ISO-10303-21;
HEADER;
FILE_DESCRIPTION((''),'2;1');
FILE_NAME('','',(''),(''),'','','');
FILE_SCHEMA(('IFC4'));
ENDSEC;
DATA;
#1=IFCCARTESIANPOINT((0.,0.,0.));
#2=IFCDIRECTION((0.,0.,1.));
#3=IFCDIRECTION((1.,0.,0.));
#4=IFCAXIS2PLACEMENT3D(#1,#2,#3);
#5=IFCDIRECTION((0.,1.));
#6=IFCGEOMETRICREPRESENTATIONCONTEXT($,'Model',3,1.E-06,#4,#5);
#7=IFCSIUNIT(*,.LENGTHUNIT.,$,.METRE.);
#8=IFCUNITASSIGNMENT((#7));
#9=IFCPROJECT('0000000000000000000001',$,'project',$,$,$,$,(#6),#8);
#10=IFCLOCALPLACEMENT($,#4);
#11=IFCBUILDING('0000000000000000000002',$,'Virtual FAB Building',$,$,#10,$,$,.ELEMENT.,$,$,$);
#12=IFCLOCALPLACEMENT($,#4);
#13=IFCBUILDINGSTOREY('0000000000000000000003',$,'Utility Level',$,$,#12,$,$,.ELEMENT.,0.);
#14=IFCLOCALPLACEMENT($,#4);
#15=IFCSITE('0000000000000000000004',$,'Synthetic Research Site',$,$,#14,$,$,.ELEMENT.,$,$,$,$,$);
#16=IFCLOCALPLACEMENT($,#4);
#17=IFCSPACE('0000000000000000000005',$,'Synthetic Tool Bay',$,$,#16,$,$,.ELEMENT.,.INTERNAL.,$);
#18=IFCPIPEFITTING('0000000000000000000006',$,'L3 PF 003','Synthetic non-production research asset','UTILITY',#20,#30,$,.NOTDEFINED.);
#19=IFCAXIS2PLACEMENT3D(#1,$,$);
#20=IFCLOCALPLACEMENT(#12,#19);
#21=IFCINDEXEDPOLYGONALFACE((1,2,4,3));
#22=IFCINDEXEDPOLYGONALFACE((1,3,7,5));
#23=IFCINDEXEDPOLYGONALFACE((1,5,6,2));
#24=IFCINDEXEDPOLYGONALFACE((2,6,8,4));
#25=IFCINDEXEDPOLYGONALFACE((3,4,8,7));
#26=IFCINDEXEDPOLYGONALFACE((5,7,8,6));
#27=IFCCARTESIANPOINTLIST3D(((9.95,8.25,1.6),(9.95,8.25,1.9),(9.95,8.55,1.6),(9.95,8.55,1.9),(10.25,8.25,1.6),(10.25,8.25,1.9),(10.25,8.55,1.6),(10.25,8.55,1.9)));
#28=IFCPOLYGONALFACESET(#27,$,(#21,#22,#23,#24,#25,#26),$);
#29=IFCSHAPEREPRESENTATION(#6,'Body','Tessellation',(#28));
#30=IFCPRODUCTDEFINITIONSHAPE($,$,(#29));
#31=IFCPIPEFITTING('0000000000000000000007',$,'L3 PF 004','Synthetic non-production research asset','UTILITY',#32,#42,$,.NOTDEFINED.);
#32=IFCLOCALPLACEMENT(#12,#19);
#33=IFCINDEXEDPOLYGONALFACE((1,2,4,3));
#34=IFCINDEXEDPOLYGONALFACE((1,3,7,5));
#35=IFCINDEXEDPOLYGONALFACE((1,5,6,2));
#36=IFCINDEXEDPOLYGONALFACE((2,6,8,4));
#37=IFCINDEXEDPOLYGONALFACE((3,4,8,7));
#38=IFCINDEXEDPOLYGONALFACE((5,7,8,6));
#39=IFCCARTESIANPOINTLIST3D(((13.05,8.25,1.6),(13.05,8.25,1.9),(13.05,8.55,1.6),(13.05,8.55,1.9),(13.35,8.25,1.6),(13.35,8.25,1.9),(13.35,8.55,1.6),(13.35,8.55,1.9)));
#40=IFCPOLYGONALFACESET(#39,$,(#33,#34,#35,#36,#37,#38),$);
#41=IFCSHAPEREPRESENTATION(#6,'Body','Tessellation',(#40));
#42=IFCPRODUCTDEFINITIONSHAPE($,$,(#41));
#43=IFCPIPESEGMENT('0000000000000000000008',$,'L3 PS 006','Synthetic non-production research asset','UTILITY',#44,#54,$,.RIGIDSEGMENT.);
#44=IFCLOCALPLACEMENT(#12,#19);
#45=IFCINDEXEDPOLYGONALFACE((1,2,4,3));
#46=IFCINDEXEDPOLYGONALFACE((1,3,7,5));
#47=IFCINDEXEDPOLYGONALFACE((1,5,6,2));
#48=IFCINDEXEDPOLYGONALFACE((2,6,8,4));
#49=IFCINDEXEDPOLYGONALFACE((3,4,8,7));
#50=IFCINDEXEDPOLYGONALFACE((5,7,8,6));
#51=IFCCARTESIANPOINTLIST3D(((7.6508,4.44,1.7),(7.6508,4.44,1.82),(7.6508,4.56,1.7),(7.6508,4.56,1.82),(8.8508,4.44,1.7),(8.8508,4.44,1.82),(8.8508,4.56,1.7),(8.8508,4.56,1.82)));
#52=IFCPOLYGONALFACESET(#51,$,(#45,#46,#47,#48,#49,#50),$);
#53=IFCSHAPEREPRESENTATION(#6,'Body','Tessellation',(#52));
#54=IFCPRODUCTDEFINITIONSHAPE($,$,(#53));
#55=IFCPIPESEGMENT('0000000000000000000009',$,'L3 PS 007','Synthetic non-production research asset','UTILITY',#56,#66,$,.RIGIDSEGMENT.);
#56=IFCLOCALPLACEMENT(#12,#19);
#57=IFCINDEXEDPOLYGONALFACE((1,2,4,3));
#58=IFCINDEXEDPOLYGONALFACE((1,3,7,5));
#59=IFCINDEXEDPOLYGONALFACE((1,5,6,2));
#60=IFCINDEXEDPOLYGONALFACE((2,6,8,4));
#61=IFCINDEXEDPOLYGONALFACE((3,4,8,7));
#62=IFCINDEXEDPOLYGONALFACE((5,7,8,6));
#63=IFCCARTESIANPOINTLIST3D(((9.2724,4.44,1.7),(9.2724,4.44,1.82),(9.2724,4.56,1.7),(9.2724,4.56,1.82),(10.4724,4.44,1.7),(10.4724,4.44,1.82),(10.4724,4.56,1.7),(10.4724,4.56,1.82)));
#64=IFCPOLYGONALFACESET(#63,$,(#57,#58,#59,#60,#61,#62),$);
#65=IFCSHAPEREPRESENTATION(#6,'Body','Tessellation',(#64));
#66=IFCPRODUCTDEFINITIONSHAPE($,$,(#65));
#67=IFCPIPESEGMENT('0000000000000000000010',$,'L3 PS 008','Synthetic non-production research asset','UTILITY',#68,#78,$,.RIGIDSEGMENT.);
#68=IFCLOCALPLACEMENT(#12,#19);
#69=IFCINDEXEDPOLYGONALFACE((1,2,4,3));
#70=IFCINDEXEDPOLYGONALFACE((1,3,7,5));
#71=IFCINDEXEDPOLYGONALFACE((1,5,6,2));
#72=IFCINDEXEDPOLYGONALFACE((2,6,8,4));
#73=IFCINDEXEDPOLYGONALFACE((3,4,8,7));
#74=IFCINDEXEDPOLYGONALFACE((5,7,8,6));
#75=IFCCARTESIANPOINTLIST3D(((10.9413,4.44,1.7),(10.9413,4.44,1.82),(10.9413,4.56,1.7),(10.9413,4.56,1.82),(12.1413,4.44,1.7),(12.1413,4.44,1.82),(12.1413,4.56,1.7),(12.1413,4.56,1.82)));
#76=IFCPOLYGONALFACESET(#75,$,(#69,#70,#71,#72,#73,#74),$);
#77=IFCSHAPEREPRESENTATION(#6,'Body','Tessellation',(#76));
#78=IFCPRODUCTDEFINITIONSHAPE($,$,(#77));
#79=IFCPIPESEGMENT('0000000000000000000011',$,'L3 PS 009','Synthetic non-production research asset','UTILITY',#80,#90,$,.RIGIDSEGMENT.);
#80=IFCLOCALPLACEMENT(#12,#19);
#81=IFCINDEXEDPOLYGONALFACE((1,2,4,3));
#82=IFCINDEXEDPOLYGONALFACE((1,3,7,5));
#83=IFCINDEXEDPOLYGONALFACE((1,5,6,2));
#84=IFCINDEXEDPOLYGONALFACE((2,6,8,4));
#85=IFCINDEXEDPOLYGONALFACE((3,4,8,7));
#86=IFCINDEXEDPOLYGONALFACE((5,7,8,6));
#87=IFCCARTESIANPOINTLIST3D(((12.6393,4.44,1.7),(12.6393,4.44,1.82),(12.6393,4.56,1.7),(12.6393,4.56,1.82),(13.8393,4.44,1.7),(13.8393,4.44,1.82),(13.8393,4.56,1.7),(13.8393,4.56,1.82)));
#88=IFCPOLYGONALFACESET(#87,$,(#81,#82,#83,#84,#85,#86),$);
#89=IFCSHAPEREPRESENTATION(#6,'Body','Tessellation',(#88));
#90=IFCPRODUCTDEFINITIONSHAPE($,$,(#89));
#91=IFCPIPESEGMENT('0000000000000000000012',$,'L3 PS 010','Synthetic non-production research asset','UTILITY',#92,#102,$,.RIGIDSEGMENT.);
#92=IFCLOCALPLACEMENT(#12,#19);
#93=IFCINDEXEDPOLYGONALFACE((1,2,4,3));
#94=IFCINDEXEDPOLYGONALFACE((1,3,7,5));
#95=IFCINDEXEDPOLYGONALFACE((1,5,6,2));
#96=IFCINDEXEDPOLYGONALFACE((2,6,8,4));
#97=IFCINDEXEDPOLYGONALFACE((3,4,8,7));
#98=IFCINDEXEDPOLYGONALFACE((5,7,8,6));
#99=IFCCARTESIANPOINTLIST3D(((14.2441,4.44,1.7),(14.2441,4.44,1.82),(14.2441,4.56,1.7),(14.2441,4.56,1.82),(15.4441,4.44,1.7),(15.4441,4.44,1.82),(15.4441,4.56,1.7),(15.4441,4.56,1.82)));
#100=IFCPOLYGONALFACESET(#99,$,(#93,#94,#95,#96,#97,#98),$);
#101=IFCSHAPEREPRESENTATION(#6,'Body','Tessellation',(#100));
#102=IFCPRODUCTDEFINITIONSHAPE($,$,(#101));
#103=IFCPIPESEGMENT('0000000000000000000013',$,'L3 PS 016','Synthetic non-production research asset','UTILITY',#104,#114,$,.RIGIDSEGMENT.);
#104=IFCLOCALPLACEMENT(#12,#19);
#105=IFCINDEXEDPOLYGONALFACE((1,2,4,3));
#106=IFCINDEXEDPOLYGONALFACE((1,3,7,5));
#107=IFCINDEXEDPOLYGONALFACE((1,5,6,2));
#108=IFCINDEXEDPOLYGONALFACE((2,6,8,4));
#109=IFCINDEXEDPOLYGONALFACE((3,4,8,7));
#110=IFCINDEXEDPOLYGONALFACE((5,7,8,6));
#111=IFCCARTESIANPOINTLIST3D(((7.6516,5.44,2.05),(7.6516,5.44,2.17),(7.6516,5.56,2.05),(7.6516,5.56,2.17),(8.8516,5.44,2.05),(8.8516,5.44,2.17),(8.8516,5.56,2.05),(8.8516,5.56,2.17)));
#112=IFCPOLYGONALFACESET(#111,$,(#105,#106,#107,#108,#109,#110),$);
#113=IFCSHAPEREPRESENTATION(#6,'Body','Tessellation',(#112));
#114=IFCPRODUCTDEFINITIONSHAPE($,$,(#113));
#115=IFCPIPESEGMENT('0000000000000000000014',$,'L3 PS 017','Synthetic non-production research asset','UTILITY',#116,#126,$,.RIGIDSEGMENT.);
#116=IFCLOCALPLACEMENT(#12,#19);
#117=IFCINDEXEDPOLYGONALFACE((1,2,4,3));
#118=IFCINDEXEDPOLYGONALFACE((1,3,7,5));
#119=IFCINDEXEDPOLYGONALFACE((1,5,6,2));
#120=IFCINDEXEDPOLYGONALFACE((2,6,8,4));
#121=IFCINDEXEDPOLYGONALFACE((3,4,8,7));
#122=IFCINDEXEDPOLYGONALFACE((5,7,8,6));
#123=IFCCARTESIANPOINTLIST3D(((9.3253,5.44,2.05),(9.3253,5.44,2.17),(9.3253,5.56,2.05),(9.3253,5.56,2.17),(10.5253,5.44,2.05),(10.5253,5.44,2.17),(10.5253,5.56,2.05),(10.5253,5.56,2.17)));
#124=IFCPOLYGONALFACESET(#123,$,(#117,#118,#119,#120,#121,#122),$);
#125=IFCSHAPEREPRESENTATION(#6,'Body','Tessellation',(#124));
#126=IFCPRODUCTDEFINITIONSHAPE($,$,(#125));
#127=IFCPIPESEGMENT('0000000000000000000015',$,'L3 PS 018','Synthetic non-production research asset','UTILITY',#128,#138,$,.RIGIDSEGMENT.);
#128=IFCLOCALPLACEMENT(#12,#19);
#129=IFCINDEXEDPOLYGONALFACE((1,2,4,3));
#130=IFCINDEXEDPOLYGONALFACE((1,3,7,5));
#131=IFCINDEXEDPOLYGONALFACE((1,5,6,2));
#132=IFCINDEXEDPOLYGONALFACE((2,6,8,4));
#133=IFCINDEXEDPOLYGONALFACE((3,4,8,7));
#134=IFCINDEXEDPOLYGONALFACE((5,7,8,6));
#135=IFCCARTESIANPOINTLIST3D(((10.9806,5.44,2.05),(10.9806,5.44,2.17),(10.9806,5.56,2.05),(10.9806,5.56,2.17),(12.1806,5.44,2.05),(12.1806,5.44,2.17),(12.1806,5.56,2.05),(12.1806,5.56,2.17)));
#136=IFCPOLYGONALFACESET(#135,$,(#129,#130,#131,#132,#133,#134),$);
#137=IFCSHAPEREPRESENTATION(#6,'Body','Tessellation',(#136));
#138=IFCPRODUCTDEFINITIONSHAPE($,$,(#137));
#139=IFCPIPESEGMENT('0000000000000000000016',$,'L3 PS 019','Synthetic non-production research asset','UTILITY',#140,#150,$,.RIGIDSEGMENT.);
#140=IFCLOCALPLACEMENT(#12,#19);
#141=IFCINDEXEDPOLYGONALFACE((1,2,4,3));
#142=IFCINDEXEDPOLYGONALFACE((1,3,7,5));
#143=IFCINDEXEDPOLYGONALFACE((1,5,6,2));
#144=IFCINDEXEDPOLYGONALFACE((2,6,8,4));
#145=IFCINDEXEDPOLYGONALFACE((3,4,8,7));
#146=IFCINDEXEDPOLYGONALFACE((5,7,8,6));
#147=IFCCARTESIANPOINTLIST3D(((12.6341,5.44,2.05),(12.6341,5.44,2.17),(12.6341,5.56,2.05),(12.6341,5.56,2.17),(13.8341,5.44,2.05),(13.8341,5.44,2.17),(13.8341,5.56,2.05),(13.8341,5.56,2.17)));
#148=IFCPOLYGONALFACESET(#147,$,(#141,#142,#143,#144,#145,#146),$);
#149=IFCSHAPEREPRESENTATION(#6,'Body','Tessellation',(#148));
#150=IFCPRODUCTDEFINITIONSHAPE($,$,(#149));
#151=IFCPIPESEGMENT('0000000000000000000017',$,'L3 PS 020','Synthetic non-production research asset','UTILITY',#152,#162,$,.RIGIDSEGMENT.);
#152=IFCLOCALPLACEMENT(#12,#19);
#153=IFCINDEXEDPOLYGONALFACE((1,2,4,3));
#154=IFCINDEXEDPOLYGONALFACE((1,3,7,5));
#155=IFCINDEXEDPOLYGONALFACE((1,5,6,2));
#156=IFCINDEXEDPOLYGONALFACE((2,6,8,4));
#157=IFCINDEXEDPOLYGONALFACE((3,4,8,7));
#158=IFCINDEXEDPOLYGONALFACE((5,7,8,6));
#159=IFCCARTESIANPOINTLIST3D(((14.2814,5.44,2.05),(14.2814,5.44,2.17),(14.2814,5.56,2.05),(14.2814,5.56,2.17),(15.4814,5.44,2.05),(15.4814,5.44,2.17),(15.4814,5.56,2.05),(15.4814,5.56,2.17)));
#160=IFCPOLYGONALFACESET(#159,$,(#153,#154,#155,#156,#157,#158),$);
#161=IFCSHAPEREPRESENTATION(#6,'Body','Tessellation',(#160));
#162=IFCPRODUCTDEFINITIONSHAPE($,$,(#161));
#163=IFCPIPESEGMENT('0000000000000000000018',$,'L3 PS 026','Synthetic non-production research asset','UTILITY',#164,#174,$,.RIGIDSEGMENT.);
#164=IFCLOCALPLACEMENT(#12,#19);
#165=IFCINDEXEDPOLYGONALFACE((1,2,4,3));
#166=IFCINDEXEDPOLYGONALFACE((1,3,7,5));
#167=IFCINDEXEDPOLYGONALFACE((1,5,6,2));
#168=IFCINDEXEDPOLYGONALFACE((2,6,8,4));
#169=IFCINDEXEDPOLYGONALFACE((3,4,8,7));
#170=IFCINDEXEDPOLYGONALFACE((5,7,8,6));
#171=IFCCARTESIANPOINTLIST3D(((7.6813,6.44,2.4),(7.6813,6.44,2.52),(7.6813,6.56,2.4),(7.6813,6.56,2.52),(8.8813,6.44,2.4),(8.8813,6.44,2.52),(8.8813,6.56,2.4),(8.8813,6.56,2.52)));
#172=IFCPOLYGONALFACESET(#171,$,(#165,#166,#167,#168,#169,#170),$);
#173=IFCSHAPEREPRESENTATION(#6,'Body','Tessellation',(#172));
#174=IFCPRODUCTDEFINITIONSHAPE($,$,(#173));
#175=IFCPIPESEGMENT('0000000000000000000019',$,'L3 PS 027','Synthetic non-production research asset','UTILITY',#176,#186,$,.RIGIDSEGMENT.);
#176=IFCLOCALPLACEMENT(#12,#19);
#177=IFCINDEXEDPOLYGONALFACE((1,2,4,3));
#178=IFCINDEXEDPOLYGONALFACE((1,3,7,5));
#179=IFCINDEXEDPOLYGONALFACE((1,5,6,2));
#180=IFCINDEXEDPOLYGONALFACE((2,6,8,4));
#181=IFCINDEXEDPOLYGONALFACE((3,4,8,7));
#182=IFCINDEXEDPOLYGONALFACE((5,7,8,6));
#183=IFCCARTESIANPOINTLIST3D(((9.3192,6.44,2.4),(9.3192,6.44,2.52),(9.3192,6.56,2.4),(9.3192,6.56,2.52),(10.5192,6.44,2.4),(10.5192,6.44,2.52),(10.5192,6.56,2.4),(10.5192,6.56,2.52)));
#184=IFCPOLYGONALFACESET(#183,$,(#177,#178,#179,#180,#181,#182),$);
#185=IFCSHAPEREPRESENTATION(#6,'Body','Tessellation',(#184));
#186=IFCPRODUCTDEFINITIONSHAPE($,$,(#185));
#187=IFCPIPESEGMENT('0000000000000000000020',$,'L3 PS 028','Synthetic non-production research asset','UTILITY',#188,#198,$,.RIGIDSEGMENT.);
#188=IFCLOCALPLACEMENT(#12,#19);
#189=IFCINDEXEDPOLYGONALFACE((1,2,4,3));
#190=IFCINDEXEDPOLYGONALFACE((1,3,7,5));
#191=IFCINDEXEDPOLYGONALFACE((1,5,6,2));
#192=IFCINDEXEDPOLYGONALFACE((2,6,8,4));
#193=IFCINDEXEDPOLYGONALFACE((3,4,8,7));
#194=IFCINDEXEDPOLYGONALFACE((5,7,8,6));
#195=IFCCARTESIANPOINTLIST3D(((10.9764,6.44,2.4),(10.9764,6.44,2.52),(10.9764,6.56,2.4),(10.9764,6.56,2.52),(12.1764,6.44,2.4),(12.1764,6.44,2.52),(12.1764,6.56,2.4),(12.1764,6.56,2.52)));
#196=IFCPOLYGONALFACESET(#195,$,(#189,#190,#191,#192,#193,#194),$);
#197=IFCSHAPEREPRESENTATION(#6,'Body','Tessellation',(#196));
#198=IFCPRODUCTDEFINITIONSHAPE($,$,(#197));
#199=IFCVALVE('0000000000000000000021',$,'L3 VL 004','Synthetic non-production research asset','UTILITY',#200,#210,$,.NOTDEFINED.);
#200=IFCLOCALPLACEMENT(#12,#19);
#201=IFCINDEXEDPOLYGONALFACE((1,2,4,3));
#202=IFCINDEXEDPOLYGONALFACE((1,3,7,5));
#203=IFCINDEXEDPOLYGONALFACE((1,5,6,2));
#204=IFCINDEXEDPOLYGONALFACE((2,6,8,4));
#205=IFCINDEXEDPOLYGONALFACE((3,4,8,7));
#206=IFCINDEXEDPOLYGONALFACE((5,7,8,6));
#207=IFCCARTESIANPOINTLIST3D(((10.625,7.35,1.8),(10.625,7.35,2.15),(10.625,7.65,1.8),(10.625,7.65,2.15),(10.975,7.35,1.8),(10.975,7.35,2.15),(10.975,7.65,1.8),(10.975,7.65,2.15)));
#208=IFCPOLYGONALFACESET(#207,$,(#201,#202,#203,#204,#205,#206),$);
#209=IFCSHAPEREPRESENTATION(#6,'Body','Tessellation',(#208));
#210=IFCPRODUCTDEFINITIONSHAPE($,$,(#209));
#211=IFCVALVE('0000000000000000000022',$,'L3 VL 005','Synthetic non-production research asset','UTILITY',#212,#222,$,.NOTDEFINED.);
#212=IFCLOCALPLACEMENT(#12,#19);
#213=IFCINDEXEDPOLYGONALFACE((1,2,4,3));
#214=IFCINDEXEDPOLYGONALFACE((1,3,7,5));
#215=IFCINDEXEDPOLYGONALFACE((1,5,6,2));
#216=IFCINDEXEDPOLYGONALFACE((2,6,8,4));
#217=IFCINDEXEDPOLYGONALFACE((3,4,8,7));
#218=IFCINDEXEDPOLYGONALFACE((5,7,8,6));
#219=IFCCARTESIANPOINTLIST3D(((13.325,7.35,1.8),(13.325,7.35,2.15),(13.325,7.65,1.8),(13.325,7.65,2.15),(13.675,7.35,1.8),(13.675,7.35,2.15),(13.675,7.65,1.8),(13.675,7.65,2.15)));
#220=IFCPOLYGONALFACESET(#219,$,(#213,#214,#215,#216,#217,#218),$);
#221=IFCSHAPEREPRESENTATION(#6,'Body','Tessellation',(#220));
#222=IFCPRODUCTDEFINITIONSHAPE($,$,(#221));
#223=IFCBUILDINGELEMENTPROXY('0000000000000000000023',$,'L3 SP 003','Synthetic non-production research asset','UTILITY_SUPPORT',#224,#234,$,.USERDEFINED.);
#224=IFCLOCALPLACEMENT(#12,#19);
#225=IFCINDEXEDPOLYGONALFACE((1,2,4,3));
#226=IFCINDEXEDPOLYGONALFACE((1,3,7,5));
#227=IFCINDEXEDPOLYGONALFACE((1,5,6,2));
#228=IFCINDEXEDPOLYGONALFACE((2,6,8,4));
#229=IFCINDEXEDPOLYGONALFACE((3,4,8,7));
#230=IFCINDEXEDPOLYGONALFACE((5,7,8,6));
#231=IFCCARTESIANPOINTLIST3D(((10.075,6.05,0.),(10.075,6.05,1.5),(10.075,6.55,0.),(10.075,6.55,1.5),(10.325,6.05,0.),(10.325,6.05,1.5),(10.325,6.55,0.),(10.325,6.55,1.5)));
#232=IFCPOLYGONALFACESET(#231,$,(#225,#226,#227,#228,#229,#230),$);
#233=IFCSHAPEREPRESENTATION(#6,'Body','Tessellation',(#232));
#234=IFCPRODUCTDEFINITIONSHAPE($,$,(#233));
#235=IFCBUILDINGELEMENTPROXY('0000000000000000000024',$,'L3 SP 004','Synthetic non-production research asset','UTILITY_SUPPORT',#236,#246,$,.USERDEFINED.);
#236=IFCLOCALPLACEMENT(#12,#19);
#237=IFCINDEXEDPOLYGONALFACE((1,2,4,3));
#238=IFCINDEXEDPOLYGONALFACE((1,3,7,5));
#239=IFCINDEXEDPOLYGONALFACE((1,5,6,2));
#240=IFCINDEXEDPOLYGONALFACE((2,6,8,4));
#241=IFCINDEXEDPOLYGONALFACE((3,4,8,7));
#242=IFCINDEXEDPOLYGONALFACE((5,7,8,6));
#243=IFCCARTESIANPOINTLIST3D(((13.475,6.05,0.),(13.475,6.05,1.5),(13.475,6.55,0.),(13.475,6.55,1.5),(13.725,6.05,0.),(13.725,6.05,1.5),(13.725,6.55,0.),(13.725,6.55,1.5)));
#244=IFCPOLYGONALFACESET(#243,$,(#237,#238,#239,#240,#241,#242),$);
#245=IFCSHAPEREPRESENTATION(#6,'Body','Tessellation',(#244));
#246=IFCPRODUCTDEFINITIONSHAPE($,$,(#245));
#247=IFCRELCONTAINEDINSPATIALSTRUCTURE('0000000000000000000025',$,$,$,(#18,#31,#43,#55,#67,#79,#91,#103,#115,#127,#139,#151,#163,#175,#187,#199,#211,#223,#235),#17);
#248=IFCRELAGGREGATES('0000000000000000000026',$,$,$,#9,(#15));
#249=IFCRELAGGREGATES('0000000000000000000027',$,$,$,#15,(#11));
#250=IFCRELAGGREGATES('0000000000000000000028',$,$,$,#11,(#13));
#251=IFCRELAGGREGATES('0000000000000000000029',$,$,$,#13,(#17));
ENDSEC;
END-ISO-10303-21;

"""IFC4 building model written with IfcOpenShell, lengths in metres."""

from ifc_helpers import new_model, si_unit, direction, frame, origin_with_axes, origin_2d_with_axis, place, context, project, spatial, rectangle, extrude, element, save


model = new_model("IFC4")

# Units and contexts
model_context = context("Model", 3, precision=1e-06, world=origin_with_axes(), true_north=direction((0.0, 1.0)))
ifc_project = project(units=[si_unit("LENGTHUNIT", "METRE")], contexts=[model_context])

# Site, building, storey, space
site_placement = place(None, origin_with_axes())
site = spatial("IfcSite", under=ifc_project, at=site_placement, Name="Synthetic Research Site", CompositionType="ELEMENT")
building_placement = place(None, origin_with_axes())
building = spatial("IfcBuilding", under=site, at=building_placement, Name="Virtual FAB Building", CompositionType="ELEMENT")
storey_placement = place(None, origin_with_axes())
storey = spatial("IfcBuildingStorey", under=building, at=storey_placement, Name="Utility Level", CompositionType="ELEMENT", Elevation=0.0)
space_placement = place(None, origin_with_axes())
space = spatial("IfcSpace", under=storey, at=space_placement, Name="Synthetic Tool Bay", CompositionType="ELEMENT", PredefinedType="INTERNAL")

# Pipe fittings
for number, where, z_axis, x_axis, name in (
    (1, (10.1, 8.4, 1.6), (0.0, 0.0, 1.0), (1.0, 0.0, 0.0), "L3 PF 003"),
    (2, (13.2, 8.4, 1.6), (0.0, 0.0, 1.0), (1.0, 0.0, 0.0), "L3 PF 004"),
):
    element("IfcPipeFitting", number, at=place(None, frame(where, z_axis=z_axis, x_axis=x_axis)), inside=space, Name=name, Description="Synthetic non-production research asset", ObjectType="UTILITY", PredefinedType="NOTDEFINED", context=model_context, shape_type="SweptSolid", body=[
        extrude(rectangle(XDim=0.3, YDim=0.3, at=origin_2d_with_axis()), origin_with_axes(), (0.0, 0.0, 1.0), 0.3),
    ])

# Pipe segments
for number, where, z_axis, x_axis, name in (
    (3, (8.2508, 4.5, 1.7), (0.0, 0.0, 1.0), (1.0, 0.0, 0.0), "L3 PS 006"),
    (4, (9.8724, 4.5, 1.7), (0.0, 0.0, 1.0), (1.0, 0.0, 0.0), "L3 PS 007"),
    (5, (11.5413, 4.5, 1.7), (0.0, 0.0, 1.0), (1.0, 0.0, 0.0), "L3 PS 008"),
    (6, (13.2393, 4.5, 1.7), (0.0, 0.0, 1.0), (1.0, 0.0, 0.0), "L3 PS 009"),
    (7, (14.8441, 4.5, 1.7), (0.0, 0.0, 1.0), (1.0, 0.0, 0.0), "L3 PS 010"),
    (8, (8.2516, 5.5, 2.05), (0.0, 0.0, 1.0), (1.0, 0.0, 0.0), "L3 PS 016"),
    (9, (9.9253, 5.5, 2.05), (0.0, 0.0, 1.0), (1.0, 0.0, 0.0), "L3 PS 017"),
    (10, (11.5806, 5.5, 2.05), (0.0, 0.0, 1.0), (1.0, 0.0, 0.0), "L3 PS 018"),
    (11, (13.2341, 5.5, 2.05), (0.0, 0.0, 1.0), (1.0, 0.0, 0.0), "L3 PS 019"),
    (12, (14.8814, 5.5, 2.05), (0.0, 0.0, 1.0), (1.0, 0.0, 0.0), "L3 PS 020"),
    (13, (8.2813, 6.5, 2.4), (0.0, 0.0, 1.0), (1.0, 0.0, 0.0), "L3 PS 026"),
    (14, (9.9192, 6.5, 2.4), (0.0, 0.0, 1.0), (1.0, 0.0, 0.0), "L3 PS 027"),
    (15, (11.5764, 6.5, 2.4), (0.0, 0.0, 1.0), (1.0, 0.0, 0.0), "L3 PS 028"),
):
    element("IfcPipeSegment", number, at=place(None, frame(where, z_axis=z_axis, x_axis=x_axis)), inside=space, Name=name, Description="Synthetic non-production research asset", ObjectType="UTILITY", PredefinedType="RIGIDSEGMENT", context=model_context, shape_type="SweptSolid", body=[
        extrude(rectangle(XDim=1.2, YDim=0.12, at=origin_2d_with_axis()), origin_with_axes(), (0.0, 0.0, 1.0), 0.12),
    ])

# Valves
for number, where, z_axis, x_axis, name in (
    (16, (10.8, 7.5, 1.8), (0.0, 0.0, 1.0), (1.0, 0.0, 0.0), "L3 VL 004"),
    (17, (13.5, 7.5, 1.8), (0.0, 0.0, 1.0), (1.0, 0.0, 0.0), "L3 VL 005"),
):
    element("IfcValve", number, at=place(None, frame(where, z_axis=z_axis, x_axis=x_axis)), inside=space, Name=name, Description="Synthetic non-production research asset", ObjectType="UTILITY", PredefinedType="NOTDEFINED", context=model_context, shape_type="SweptSolid", body=[
        extrude(rectangle(XDim=0.35, YDim=0.3, at=origin_2d_with_axis()), origin_with_axes(), (0.0, 0.0, 1.0), 0.35),
    ])

# Building element proxies
for number, where, z_axis, x_axis, name in (
    (18, (10.2, 6.3, 0.0), (0.0, 0.0, 1.0), (1.0, 0.0, 0.0), "L3 SP 003"),
    (19, (13.6, 6.3, 0.0), (0.0, 0.0, 1.0), (1.0, 0.0, 0.0), "L3 SP 004"),
):
    element("IfcBuildingElementProxy", number, at=place(None, frame(where, z_axis=z_axis, x_axis=x_axis)), inside=space, Name=name, Description="Synthetic non-production research asset", ObjectType="UTILITY_SUPPORT", PredefinedType="USERDEFINED", context=model_context, shape_type="SweptSolid", body=[
        extrude(rectangle(XDim=0.25, YDim=0.5, at=origin_2d_with_axis()), origin_with_axes(), (0.0, 0.0, 1.0), 1.5),
    ])

save(model, "model.ifc")
